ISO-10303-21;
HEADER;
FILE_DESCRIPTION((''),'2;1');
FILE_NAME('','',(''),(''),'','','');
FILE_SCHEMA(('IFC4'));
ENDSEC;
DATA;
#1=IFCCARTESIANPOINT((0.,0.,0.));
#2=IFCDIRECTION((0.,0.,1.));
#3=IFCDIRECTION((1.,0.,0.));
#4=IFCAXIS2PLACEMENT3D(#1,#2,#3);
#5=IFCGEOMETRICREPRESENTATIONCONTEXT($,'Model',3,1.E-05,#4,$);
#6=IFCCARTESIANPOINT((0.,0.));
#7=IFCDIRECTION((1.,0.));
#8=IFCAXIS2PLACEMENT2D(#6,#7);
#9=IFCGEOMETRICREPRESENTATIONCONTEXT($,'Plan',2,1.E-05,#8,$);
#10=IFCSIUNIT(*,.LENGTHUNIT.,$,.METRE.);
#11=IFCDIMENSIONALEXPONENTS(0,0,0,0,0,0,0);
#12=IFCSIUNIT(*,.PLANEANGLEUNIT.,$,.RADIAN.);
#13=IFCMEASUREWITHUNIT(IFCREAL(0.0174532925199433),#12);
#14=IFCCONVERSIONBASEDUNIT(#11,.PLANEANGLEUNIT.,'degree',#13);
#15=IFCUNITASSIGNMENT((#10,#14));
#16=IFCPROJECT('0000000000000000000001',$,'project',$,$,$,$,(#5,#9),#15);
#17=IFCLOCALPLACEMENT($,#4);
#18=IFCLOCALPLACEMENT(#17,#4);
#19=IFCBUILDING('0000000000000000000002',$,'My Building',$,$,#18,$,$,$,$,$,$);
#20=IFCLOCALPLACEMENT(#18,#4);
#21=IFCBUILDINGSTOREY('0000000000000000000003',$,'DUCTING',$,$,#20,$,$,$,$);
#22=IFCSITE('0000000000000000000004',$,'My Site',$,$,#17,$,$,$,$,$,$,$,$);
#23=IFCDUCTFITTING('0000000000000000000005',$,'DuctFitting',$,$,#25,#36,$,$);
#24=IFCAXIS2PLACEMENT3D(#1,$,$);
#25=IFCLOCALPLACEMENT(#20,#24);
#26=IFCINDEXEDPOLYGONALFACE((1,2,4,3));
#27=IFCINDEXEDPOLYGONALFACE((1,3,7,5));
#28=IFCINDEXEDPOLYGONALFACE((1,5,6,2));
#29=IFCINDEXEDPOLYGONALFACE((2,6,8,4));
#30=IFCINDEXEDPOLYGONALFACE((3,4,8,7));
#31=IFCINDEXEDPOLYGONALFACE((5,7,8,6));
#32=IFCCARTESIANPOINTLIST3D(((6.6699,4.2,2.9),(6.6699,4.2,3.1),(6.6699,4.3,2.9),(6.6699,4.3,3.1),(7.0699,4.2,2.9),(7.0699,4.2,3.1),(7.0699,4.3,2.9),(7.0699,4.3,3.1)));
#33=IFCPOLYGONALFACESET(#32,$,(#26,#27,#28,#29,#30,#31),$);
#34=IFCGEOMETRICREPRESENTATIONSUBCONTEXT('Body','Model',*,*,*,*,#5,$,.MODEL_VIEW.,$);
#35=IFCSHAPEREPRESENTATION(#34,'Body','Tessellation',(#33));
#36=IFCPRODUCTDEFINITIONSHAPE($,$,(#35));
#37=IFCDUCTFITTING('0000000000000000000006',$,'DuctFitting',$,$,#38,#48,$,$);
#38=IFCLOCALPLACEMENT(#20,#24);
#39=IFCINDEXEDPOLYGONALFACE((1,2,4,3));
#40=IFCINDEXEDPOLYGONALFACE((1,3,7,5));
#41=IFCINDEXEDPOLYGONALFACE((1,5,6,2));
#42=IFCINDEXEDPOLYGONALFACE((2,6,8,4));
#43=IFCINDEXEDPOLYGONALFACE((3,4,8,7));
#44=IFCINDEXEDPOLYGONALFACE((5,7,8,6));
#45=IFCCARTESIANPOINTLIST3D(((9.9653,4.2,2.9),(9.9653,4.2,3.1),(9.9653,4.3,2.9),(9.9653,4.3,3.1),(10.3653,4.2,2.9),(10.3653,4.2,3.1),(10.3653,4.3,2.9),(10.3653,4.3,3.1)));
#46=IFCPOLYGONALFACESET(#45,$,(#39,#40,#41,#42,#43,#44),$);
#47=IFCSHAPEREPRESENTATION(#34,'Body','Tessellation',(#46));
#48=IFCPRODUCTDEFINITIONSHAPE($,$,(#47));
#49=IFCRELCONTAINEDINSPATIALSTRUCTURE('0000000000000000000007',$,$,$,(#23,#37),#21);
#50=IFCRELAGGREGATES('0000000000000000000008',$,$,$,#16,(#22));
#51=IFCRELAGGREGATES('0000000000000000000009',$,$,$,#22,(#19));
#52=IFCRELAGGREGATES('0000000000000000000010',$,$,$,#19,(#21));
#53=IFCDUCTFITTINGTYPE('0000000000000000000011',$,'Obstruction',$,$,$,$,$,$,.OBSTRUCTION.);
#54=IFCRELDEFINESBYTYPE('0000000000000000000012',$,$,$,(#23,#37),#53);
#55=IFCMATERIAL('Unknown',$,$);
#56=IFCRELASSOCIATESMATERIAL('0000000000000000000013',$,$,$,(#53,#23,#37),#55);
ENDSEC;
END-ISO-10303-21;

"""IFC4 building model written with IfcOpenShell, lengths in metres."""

from ifc_helpers import new_model, entity, si_unit, converted_unit, frame, origin_with_axes, origin_2d_with_axis, place, context, subcontext, project, spatial, rectangle, extrude, material, material_profile, profile_set, profile_usage, type_object, element, save


model = new_model("IFC4")

# Units and contexts
model_context = context("Model", 3, precision=1e-05, world=origin_with_axes())
plan_context = context("Plan", 2, precision=1e-05, world=origin_2d_with_axis())
body_context = subcontext(model_context, "Body", "Model", "MODEL_VIEW")
ifc_project = project(units=[si_unit("LENGTHUNIT", "METRE"), converted_unit("PLANEANGLEUNIT", "degree", entity("IfcReal", 0.0174532925199433), si_unit("PLANEANGLEUNIT", "RADIAN"), dimensions=[0, 0, 0, 0, 0, 0, 0])], contexts=[model_context, plan_context])

# Site, building, storey
site_placement = place(None, origin_with_axes())
site = spatial("IfcSite", under=ifc_project, at=site_placement, Name="My Site")
building_placement = place(site_placement, origin_with_axes())
building = spatial("IfcBuilding", under=site, at=building_placement, Name="My Building")
storey_placement = place(building_placement, origin_with_axes())
storey = spatial("IfcBuildingStorey", under=building, at=storey_placement, Name="DUCTING")

# Shared definitions
ifc_material = material(Name="Unknown")

# Duct fittings
ifc_material_profile_1 = material_profile(ifc_material, rectangle(XDim=0.4, YDim=0.2))
ifc_profile_set_1 = profile_set([ifc_material_profile_1])
duct_fitting_type_1 = type_object("IfcDuctFittingType", Name="Obstruction", PredefinedType="OBSTRUCTION", material=ifc_profile_set_1)
ifc_profile_usage_1 = profile_usage(ifc_profile_set_1, cardinal=5)
duct_fitting_1_placement = place(storey_placement, frame((6.8699, 4.3, 3.0), z_axis=(0.0, -1.0, 0.0), x_axis=(1.0, 0.0, 0.0)))
element("IfcDuctFitting", 1, at=duct_fitting_1_placement, inside=storey, type_object=duct_fitting_type_1, material=ifc_profile_usage_1, Name="DuctFitting", context=body_context, shape_type="SweptSolid", body=[
    extrude(rectangle(XDim=0.4, YDim=0.2), origin_with_axes(), (0.0, 0.0, 1.0), 0.1),
])
ifc_profile_usage_2 = profile_usage(ifc_profile_set_1, cardinal=5)
duct_fitting_2_placement = place(storey_placement, frame((10.1653, 4.3, 3.0), z_axis=(0.0, -1.0, 0.0), x_axis=(1.0, 0.0, 0.0)))
element("IfcDuctFitting", 2, at=duct_fitting_2_placement, inside=storey, type_object=duct_fitting_type_1, material=ifc_profile_usage_2, Name="DuctFitting", context=body_context, shape_type="SweptSolid", body=[
    extrude(rectangle(XDim=0.4, YDim=0.2), origin_with_axes(), (0.0, 0.0, 1.0), 0.1),
])

save(model, "model.ifc")
